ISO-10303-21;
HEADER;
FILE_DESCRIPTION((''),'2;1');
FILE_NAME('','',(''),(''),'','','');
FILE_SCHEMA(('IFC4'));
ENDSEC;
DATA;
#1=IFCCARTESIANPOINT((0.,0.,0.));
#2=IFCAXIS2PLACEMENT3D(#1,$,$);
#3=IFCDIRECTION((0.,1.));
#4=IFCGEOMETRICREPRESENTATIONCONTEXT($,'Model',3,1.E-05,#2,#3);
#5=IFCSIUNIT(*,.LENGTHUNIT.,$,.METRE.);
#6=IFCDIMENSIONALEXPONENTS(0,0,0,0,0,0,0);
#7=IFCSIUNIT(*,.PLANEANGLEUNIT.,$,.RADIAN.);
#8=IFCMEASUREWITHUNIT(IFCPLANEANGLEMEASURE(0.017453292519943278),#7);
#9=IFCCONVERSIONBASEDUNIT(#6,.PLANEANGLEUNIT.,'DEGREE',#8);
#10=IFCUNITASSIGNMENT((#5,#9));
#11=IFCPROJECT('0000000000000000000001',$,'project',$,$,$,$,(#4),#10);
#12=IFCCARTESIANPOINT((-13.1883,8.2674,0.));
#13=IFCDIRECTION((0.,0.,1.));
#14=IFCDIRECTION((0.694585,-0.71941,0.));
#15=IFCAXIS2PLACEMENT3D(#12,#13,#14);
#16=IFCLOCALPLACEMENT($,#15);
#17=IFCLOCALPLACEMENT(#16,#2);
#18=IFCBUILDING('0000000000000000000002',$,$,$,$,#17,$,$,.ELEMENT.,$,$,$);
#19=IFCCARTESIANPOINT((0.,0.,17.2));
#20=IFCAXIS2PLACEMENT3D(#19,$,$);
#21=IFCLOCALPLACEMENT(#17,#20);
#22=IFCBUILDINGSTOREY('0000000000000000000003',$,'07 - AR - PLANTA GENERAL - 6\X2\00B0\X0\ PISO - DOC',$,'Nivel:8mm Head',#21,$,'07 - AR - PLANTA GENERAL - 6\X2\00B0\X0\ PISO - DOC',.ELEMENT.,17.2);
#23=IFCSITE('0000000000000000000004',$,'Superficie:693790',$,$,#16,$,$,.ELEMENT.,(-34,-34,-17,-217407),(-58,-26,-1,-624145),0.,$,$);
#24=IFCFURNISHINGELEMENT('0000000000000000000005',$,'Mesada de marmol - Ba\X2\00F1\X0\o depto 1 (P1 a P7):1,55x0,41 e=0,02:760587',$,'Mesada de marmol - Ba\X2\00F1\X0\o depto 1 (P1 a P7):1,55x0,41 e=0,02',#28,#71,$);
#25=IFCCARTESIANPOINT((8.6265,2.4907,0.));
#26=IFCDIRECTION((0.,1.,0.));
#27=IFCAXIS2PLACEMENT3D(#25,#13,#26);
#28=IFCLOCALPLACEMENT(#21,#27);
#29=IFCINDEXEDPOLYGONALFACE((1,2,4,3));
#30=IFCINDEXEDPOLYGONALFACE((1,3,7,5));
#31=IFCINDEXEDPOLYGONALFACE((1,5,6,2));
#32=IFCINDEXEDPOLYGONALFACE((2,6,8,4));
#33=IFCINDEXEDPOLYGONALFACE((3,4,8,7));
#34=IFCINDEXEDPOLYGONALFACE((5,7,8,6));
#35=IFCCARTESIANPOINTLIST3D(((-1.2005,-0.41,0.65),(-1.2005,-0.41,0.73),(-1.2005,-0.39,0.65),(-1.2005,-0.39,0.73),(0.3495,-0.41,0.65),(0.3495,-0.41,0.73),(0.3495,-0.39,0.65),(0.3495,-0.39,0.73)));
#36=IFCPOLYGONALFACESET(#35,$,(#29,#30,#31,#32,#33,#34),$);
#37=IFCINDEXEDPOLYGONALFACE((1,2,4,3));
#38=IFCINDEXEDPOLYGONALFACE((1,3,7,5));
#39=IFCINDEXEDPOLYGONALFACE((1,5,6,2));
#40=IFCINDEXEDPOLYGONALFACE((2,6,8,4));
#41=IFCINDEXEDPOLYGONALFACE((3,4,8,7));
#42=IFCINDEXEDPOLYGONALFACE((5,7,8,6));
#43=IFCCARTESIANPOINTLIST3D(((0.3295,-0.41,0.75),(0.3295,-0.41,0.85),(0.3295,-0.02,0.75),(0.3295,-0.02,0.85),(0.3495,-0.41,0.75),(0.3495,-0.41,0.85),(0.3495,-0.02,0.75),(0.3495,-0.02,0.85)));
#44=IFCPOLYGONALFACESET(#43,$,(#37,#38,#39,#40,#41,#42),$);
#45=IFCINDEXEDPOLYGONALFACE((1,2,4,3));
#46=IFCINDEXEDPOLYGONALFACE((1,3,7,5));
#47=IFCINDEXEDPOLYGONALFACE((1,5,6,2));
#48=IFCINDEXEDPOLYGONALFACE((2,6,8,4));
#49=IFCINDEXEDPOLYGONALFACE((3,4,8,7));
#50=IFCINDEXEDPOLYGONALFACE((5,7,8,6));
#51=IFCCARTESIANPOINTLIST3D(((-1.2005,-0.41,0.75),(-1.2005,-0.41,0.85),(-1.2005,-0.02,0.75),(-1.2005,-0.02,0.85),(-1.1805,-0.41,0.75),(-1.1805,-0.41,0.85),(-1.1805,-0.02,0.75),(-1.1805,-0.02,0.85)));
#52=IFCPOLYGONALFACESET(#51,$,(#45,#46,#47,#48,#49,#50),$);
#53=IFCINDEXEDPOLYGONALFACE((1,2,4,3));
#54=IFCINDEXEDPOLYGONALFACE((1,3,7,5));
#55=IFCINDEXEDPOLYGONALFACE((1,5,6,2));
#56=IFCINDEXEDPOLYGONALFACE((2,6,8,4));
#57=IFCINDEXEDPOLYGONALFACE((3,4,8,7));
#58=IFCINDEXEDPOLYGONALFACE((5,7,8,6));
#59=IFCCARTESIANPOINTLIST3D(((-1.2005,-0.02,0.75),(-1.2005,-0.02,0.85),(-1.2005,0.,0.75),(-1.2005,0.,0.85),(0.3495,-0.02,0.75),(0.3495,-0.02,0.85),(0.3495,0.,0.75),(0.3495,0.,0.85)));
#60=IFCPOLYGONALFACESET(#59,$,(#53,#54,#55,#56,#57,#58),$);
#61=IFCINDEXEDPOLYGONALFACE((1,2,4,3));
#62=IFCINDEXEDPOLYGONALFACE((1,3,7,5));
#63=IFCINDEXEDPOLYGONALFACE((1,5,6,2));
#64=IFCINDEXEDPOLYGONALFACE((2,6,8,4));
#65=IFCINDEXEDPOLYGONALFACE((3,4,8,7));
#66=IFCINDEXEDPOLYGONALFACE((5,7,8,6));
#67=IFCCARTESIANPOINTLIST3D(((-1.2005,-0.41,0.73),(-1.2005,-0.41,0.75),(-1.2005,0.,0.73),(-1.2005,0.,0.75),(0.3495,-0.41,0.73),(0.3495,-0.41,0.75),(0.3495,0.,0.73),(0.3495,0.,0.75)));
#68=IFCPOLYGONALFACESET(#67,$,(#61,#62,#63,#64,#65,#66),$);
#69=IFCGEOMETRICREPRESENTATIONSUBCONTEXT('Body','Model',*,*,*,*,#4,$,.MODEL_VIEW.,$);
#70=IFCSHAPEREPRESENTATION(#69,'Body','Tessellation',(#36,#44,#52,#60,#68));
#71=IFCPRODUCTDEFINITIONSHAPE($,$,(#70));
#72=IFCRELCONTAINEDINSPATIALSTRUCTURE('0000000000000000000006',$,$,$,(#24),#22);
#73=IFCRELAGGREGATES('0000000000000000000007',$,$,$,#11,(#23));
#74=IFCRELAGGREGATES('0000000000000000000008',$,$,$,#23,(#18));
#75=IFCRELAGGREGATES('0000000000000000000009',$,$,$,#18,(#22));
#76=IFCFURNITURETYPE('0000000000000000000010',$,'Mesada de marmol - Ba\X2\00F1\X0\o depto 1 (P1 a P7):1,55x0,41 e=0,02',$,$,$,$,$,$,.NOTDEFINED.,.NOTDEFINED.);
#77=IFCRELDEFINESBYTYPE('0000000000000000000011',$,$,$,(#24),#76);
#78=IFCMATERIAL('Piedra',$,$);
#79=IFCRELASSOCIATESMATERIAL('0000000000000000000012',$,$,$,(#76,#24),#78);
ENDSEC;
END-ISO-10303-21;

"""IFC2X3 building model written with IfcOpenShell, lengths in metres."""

from ifc_helpers import new_model, entity, si_unit, converted_unit, direction, frame, frame_2d, origin, origin_2d_with_axis, place, context, subcontext, project, spatial, rectangle, extrude, source, transform, mapped, material, type_object, type_shapes, element, save


model = new_model("IFC2X3")

# Units and contexts
model_context = context("Model", 3, precision=1e-05, world=origin(), true_north=direction((0.0, 1.0)))
body_context = subcontext(model_context, "Body", "Model", "MODEL_VIEW")
ifc_project = project(units=[si_unit("LENGTHUNIT", "METRE"), converted_unit("PLANEANGLEUNIT", "DEGREE", entity("IfcPlaneAngleMeasure", 0.017453292519943278), si_unit("PLANEANGLEUNIT", "RADIAN"), dimensions=[0, 0, 0, 0, 0, 0, 0])], contexts=[model_context])

# Site, building, storey
site_placement = place(None, frame((-13.1883, 8.2674, 0.0), z_axis=(0.0, 0.0, 1.0), x_axis=(0.694585, -0.71941, 0.0)))
site = spatial("IfcSite", under=ifc_project, at=site_placement, Name="Superficie:693790", CompositionType="ELEMENT", RefLatitude=(-34, -34, -17, -217407), RefLongitude=(-58, -26, -1, -624145), RefElevation=0.0)
building_placement = place(site_placement, origin())
building = spatial("IfcBuilding", under=site, at=building_placement, CompositionType="ELEMENT")
storey_placement = place(building_placement, frame((0.0, 0.0, 17.2)))
storey = spatial("IfcBuildingStorey", under=building, at=storey_placement, Name="07 - AR - PLANTA GENERAL - 6° PISO - DOC", ObjectType="Nivel:8mm Head", LongName="07 - AR - PLANTA GENERAL - 6° PISO - DOC", CompositionType="ELEMENT", Elevation=17.2)

# Furnishing element
ifc_material_1 = material(Name="Piedra")
furniture_type = type_object("IfcFurnitureType", Name="Mesada de marmol - Baño depto 1 (P1 a P7):1,55x0,41 e=0,02", AssemblyPlace="NOTDEFINED", material=ifc_material_1)
shared_shape_1 = source(origin(), body_context, "Body", "SweptSolid", [
    extrude(rectangle(XDim=0.02, YDim=1.55, at=frame_2d((0.0, 0.0), x_axis=(1.0, 0.0))), frame((-0.4255, -0.4, 0.65), z_axis=(0.0, 0.0, 1.0), x_axis=(0.0, 1.0, 0.0)), (0.0, 0.0, 1.0), 0.08),
    extrude(rectangle(XDim=0.39, YDim=0.02, at=origin_2d_with_axis()), frame((0.3395, -0.215, 0.75), z_axis=(0.0, 0.0, 1.0), x_axis=(0.0, 1.0, 0.0)), (0.0, 0.0, 1.0), 0.1),
    extrude(rectangle(XDim=0.02, YDim=0.39, at=origin_2d_with_axis()), frame((-1.1905, -0.215, 0.75), z_axis=(0.0, 0.0, 1.0), x_axis=(-1.0, 0.0, 0.0)), (0.0, 0.0, 1.0), 0.1),
    extrude(rectangle(XDim=0.02, YDim=1.55, at=origin_2d_with_axis()), frame((-0.4255, -0.01, 0.75), z_axis=(0.0, 0.0, 1.0), x_axis=(0.0, -1.0, 0.0)), (0.0, 0.0, 1.0), 0.1),
    extrude(rectangle(XDim=1.55, YDim=0.41, at=origin_2d_with_axis()), frame((-0.4255, -0.205, 0.73), z_axis=(0.0, 0.0, 1.0), x_axis=(-1.0, 0.0, 0.0)), (0.0, 0.0, 1.0), 0.02),
])
type_shapes(furniture_type, [shared_shape_1])
furnishing_placement = place(storey_placement, frame((8.6265, 2.4907, 0.0), z_axis=(0.0, 0.0, 1.0), x_axis=(0.0, 1.0, 0.0)))
element("IfcFurnishingElement", 1, at=furnishing_placement, inside=storey, type_object=furniture_type, material=ifc_material_1, Name="Mesada de marmol - Baño depto 1 (P1 a P7):1,55x0,41 e=0,02:760587", ObjectType="Mesada de marmol - Baño depto 1 (P1 a P7):1,55x0,41 e=0,02", context=body_context, shape_type="MappedRepresentation", body=[
    mapped(shared_shape_1, transform((0.0, 0.0, 0.0), scale=1.0)),
])

save(model, "model.ifc")
